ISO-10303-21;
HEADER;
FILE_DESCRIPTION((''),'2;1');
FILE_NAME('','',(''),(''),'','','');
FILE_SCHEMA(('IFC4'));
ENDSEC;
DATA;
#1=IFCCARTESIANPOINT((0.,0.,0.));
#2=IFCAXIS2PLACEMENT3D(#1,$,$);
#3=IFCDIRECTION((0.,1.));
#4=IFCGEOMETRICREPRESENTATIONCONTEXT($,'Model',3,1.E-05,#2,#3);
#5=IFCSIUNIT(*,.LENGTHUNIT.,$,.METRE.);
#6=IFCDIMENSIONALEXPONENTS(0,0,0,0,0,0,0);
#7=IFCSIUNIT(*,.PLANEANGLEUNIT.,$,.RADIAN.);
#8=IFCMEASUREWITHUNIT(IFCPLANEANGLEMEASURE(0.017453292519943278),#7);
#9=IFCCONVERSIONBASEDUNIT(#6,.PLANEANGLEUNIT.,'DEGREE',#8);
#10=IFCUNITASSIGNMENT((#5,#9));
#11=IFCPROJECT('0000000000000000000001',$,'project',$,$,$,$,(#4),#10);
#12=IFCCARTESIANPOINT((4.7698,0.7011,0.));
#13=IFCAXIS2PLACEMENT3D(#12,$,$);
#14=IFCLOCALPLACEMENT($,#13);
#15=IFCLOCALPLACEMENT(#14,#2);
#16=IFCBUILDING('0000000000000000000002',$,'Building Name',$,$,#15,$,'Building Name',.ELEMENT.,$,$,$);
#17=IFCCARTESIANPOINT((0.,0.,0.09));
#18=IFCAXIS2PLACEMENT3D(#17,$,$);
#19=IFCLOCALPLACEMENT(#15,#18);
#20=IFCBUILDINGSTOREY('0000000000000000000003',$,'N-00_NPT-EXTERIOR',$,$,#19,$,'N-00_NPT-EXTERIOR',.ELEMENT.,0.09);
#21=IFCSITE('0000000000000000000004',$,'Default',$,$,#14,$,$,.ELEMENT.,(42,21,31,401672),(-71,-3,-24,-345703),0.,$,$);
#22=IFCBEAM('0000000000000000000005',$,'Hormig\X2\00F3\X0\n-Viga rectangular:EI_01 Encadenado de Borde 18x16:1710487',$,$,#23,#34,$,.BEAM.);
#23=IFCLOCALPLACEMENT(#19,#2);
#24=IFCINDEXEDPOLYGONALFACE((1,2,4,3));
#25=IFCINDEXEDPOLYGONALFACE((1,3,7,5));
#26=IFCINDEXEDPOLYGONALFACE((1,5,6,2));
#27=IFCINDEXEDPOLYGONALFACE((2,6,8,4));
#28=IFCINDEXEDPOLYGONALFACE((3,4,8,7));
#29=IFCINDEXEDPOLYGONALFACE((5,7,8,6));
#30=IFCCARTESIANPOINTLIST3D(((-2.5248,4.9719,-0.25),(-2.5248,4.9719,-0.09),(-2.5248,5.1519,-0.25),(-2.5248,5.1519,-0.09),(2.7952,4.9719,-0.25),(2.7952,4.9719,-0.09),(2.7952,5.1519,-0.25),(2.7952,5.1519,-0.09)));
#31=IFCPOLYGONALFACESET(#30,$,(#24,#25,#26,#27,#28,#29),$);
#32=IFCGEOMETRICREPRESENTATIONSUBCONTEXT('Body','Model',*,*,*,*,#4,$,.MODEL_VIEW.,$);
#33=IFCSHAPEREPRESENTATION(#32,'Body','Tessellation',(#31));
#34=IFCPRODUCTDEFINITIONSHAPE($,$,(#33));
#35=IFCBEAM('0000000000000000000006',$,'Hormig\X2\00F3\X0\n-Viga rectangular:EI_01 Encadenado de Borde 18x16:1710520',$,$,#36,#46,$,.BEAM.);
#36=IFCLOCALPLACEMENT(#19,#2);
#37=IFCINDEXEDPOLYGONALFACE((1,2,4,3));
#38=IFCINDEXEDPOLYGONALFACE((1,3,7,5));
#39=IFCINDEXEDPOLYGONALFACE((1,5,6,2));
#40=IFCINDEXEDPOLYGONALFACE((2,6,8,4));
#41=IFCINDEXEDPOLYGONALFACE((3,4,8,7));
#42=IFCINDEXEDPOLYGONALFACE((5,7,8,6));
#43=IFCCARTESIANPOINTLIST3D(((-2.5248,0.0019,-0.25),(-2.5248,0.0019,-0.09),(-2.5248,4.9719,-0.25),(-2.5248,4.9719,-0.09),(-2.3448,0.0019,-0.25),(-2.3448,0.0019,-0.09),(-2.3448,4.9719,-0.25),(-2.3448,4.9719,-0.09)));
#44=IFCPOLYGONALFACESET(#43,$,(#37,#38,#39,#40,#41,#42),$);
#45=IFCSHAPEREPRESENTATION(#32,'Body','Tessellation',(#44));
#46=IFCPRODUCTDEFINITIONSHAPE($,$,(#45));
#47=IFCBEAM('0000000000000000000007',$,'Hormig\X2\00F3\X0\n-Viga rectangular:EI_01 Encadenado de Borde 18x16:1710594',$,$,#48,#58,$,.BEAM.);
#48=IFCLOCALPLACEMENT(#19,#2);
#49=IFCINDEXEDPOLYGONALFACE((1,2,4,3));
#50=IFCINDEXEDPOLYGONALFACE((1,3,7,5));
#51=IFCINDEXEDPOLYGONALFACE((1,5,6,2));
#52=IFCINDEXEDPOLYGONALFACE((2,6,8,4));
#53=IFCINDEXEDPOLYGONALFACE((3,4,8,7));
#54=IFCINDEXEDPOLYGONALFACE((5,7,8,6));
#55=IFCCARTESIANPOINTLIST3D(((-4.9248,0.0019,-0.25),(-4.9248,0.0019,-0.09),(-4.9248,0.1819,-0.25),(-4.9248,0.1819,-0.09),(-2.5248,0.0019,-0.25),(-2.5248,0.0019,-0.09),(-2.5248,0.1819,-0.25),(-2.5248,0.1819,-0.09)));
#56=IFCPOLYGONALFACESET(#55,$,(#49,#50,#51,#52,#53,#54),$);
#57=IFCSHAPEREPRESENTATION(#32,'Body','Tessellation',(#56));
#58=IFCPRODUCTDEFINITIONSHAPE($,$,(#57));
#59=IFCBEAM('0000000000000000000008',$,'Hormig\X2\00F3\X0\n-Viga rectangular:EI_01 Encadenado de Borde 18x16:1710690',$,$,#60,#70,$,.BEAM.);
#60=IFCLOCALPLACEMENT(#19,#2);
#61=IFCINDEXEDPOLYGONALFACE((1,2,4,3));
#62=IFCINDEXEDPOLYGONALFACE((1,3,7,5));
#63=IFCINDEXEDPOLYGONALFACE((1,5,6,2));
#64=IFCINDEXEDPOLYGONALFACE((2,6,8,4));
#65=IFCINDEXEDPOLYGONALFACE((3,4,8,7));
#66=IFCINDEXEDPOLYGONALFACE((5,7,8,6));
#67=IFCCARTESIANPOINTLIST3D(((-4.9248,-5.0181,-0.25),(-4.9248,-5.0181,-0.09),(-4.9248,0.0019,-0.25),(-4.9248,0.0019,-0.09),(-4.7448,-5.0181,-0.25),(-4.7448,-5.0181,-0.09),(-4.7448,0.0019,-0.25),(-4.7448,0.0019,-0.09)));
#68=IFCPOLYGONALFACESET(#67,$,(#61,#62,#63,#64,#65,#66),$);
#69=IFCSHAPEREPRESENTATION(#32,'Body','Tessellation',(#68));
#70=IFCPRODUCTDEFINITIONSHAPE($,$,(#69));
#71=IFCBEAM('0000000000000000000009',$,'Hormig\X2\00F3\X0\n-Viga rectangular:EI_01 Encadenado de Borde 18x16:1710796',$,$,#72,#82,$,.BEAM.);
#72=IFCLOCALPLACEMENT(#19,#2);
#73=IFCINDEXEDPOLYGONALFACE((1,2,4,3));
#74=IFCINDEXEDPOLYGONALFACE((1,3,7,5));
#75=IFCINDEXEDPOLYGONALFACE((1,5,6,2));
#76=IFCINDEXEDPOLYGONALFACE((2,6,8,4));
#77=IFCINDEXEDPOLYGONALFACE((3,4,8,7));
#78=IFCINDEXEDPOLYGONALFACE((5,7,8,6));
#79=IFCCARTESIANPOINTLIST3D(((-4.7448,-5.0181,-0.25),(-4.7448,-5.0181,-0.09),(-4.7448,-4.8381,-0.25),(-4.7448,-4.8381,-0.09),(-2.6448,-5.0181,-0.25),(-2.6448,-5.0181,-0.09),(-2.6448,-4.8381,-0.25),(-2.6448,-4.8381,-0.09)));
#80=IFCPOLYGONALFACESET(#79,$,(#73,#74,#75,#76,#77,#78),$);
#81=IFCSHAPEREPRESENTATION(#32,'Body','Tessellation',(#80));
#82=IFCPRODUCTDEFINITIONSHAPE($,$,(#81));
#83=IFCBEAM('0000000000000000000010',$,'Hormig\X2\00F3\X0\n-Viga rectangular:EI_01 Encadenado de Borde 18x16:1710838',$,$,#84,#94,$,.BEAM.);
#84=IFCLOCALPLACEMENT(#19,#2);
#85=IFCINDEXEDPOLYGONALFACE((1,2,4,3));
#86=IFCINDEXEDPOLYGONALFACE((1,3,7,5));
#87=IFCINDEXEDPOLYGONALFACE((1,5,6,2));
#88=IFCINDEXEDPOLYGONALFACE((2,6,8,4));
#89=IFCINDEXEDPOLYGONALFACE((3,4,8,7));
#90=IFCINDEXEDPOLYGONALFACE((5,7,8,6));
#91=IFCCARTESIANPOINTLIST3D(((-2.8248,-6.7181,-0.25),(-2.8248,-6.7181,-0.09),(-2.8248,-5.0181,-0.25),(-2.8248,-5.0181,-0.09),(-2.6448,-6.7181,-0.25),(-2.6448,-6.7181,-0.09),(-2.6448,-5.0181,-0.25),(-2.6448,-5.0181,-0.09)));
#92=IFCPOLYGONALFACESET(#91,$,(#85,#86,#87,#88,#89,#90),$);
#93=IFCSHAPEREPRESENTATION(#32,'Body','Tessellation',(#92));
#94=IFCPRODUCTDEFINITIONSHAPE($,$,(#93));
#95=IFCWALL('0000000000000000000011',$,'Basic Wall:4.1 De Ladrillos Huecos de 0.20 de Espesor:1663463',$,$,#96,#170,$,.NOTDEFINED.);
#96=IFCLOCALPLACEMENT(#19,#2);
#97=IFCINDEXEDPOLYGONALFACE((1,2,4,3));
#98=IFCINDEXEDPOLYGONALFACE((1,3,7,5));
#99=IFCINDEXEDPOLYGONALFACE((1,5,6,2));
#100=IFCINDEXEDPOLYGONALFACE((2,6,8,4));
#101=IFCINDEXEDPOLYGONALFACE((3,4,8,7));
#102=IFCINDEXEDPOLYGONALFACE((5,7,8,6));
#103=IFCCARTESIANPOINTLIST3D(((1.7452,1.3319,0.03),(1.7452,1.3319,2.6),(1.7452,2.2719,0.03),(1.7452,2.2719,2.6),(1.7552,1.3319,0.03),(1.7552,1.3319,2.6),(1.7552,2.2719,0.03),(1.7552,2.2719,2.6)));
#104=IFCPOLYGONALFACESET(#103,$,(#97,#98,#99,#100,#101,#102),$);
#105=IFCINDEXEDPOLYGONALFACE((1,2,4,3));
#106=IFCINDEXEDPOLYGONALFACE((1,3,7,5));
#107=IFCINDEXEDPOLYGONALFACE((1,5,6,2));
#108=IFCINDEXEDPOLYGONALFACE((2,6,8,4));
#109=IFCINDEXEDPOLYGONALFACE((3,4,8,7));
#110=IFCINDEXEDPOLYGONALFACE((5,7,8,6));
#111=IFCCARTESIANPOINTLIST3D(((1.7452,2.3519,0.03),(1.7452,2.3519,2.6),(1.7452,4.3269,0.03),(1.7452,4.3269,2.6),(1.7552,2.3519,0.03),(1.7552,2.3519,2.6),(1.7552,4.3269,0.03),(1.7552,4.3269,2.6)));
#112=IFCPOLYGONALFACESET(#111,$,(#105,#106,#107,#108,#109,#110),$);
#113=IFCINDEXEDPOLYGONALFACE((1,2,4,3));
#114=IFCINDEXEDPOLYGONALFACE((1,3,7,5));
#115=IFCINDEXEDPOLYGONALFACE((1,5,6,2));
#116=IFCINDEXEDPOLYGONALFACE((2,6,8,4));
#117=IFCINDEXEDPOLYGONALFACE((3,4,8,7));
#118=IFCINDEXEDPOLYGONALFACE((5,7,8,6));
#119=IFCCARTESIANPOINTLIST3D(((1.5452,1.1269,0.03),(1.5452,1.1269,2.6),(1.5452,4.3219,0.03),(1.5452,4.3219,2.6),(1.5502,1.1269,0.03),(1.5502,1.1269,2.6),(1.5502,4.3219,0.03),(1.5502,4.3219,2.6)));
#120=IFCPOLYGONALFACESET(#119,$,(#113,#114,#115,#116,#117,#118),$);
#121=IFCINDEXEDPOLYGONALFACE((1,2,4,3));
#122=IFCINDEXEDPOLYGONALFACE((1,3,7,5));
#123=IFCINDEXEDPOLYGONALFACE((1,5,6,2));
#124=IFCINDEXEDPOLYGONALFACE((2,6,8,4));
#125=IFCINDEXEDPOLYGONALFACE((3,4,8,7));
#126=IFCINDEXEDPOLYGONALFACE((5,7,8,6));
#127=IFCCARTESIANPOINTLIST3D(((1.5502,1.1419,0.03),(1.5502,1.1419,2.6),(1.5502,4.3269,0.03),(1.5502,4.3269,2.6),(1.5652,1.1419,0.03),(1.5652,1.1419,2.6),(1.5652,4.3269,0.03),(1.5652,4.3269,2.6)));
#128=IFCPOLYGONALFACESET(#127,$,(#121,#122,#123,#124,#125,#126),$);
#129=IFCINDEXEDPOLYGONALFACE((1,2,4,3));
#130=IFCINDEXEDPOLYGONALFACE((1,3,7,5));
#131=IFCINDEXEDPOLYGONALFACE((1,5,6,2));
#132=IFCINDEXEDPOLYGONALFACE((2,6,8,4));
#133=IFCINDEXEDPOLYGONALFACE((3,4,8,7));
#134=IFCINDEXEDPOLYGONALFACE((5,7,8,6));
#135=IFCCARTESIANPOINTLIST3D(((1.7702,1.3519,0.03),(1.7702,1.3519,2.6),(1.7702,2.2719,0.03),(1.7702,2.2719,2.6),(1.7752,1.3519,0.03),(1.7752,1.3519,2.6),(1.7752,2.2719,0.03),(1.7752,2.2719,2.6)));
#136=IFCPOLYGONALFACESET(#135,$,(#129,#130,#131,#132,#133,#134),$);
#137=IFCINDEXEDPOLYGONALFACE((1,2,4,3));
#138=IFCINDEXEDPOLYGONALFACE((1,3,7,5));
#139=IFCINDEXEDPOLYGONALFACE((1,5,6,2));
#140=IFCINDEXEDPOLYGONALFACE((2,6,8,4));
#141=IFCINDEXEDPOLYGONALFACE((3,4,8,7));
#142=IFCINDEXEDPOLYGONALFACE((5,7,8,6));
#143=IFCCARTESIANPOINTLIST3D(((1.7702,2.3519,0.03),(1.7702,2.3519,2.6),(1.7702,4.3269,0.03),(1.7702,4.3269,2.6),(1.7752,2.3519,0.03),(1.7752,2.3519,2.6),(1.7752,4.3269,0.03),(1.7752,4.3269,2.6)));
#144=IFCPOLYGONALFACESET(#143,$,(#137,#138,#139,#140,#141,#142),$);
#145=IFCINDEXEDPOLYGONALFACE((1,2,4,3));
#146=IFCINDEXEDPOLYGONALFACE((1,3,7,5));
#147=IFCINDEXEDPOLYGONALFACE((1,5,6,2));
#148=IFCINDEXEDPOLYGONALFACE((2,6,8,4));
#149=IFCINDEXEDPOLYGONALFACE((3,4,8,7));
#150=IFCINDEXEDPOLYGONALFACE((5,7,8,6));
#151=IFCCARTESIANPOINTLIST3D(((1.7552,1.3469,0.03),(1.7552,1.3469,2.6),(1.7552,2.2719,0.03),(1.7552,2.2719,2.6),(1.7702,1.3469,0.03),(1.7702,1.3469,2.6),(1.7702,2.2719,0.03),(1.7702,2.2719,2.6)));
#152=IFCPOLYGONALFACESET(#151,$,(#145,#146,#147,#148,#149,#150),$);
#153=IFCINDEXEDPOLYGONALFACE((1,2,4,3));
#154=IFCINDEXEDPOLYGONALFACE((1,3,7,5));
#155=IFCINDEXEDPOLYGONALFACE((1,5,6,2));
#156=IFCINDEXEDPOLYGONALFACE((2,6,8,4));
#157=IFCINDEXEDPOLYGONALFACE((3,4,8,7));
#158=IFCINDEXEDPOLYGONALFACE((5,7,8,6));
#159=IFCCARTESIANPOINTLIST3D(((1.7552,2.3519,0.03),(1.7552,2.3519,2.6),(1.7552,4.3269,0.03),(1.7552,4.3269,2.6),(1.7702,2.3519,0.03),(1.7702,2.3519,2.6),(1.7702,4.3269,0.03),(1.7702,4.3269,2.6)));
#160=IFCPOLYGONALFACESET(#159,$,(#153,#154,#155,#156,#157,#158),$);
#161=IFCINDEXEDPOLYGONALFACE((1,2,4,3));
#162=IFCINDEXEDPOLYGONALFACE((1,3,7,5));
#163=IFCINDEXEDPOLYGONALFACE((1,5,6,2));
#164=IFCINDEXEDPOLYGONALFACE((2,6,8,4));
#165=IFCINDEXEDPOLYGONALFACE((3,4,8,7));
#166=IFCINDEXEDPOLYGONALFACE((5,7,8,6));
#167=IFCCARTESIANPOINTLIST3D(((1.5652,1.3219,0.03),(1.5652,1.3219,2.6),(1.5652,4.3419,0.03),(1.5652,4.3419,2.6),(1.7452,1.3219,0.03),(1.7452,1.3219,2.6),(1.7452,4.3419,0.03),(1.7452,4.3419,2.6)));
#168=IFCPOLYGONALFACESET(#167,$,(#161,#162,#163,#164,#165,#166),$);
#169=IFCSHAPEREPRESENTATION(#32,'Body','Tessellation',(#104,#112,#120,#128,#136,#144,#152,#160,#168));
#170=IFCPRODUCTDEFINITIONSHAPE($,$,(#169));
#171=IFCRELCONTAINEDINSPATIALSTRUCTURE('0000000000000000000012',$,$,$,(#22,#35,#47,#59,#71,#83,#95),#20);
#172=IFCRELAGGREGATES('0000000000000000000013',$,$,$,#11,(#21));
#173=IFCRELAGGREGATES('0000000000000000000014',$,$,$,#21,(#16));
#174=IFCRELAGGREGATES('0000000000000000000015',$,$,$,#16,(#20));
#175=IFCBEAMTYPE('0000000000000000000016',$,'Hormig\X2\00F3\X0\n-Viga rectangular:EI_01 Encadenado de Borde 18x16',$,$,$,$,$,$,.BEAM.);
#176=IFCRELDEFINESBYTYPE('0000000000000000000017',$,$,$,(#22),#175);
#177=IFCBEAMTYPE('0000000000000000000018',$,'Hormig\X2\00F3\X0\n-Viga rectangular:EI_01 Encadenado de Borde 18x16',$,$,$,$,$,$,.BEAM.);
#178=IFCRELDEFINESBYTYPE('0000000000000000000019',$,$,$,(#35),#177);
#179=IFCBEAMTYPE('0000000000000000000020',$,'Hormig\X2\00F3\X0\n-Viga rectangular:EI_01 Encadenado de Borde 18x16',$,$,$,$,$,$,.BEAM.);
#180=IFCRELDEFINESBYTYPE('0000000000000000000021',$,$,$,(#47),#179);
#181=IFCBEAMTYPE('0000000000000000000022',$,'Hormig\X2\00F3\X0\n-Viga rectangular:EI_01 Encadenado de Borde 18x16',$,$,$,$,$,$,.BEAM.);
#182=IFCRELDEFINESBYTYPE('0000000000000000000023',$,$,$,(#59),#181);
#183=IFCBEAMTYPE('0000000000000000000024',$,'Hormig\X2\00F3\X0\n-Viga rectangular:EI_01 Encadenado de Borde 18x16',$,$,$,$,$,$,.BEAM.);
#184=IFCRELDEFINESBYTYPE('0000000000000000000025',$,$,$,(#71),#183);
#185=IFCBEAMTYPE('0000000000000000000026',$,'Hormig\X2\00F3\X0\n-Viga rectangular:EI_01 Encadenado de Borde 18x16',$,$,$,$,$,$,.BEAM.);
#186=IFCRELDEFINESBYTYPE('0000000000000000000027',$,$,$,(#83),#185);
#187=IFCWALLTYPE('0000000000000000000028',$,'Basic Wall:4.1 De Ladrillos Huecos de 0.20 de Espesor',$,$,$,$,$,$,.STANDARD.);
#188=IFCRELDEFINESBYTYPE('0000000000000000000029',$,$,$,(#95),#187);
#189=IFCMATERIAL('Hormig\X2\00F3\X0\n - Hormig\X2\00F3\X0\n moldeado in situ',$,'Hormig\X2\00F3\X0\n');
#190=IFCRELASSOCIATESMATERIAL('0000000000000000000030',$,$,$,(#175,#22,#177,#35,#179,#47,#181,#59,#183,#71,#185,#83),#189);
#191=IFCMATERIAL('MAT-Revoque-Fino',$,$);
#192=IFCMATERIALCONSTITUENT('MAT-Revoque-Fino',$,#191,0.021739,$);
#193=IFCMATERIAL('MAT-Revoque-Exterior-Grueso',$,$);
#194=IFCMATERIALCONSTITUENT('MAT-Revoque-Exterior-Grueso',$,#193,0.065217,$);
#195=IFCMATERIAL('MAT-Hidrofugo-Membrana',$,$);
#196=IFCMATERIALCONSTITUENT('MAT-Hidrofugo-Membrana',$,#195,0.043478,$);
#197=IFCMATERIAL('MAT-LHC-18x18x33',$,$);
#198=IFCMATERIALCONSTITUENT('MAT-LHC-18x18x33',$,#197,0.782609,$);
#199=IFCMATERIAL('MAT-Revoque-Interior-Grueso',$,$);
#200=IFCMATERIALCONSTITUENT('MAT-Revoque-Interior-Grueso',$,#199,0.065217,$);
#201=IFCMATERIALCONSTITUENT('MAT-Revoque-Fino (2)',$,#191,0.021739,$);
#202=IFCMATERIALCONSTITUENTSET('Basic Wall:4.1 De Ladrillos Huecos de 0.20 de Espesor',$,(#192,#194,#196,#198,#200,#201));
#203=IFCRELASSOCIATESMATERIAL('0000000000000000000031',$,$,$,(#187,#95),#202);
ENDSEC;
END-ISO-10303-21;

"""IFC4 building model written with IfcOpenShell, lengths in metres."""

from ifc_helpers import new_model, entity, si_unit, converted_unit, direction, frame, origin, place, context, subcontext, project, spatial, indexed_curve, outline, extrude, source, transform, mapped, material, constituent, constituent_set, type_object, type_shapes, element, save


model = new_model("IFC4")

# Units and contexts
model_context = context("Model", 3, precision=1e-05, world=origin(), true_north=direction((0.0, 1.0)))
body_context = subcontext(model_context, "Body", "Model", "MODEL_VIEW")
ifc_project = project(units=[si_unit("LENGTHUNIT", "METRE"), converted_unit("PLANEANGLEUNIT", "DEGREE", entity("IfcPlaneAngleMeasure", 0.017453292519943278), si_unit("PLANEANGLEUNIT", "RADIAN"), dimensions=[0, 0, 0, 0, 0, 0, 0])], contexts=[model_context])

# Site, building, storey
site_placement = place(None, frame((4.7698, 0.7011, 0.0)))
site = spatial("IfcSite", under=ifc_project, at=site_placement, Name="Default", CompositionType="ELEMENT", RefLatitude=(42, 21, 31, 401672), RefLongitude=(-71, -3, -24, -345703), RefElevation=0.0)
building_placement = place(site_placement, origin())
building = spatial("IfcBuilding", under=site, at=building_placement, Name="Building Name", LongName="Building Name", CompositionType="ELEMENT")
storey_placement = place(building_placement, frame((0.0, 0.0, 0.09)))
storey = spatial("IfcBuildingStorey", under=building, at=storey_placement, Name="N-00_NPT-EXTERIOR", LongName="N-00_NPT-EXTERIOR", CompositionType="ELEMENT", Elevation=0.09)

# Beams
ifc_material_1 = material(Name="Hormigón - Hormigón moldeado in situ", Category="Hormigón")
beam_type_1 = type_object("IfcBeamType", Name="Hormigón-Viga rectangular:EI_01 Encadenado de Borde 18x16", PredefinedType="BEAM", material=ifc_material_1)
shared_shape_1 = source(origin(), body_context, "Body", "SweptSolid", [
    extrude(outline(indexed_curve([(-0.08, -0.09), (0.08, -0.09), (0.08, 0.09), (-0.08, 0.09), (-0.08, -0.09)], self_intersect=False)), frame((2.7952, 5.0619, -0.08), z_axis=(-1.0, 0.0, 0.0), x_axis=(0.0, 0.0, -1.0)), (0.0, 0.0, 1.0), 5.32),
])
type_shapes(beam_type_1, [shared_shape_1])
beam_1_placement = place(storey_placement, frame((0.0, 0.0, -0.09)))
element("IfcBeam", 1, at=beam_1_placement, inside=storey, type_object=beam_type_1, material=ifc_material_1, Name="Hormigón-Viga rectangular:EI_01 Encadenado de Borde 18x16:1710487", PredefinedType="BEAM", context=body_context, shape_type="MappedRepresentation", body=[
    mapped(shared_shape_1, transform((0.0, 0.0, 0.0), scale=1.0)),
])
beam_type_2 = type_object("IfcBeamType", Name="Hormigón-Viga rectangular:EI_01 Encadenado de Borde 18x16", PredefinedType="BEAM", material=ifc_material_1)
shared_shape_2 = source(origin(), body_context, "Body", "SweptSolid", [
    extrude(outline(indexed_curve([(-0.09, -0.08), (0.09, -0.08), (0.09, 0.08), (-0.09, 0.08), (-0.09, -0.08)], self_intersect=False)), frame((-2.4348, 4.9719, -0.08), z_axis=(0.0, -1.0, 0.0), x_axis=(-1.0, 0.0, 0.0)), (0.0, 0.0, 1.0), 4.97),
])
type_shapes(beam_type_2, [shared_shape_2])
beam_2_placement = place(storey_placement, frame((0.0, 0.0, -0.09)))
element("IfcBeam", 2, at=beam_2_placement, inside=storey, type_object=beam_type_2, material=ifc_material_1, Name="Hormigón-Viga rectangular:EI_01 Encadenado de Borde 18x16:1710520", PredefinedType="BEAM", context=body_context, shape_type="MappedRepresentation", body=[
    mapped(shared_shape_2, transform((0.0, 0.0, 0.0), scale=1.0)),
])
beam_type_3 = type_object("IfcBeamType", Name="Hormigón-Viga rectangular:EI_01 Encadenado de Borde 18x16", PredefinedType="BEAM", material=ifc_material_1)
shared_shape_3 = source(origin(), body_context, "Body", "SweptSolid", [
    extrude(outline(indexed_curve([(-0.08, -0.09), (0.08, -0.09), (0.08, 0.09), (-0.08, 0.09), (-0.08, -0.09)], self_intersect=False)), frame((-2.5248, 0.0919, -0.08), z_axis=(-1.0, 0.0, 0.0), x_axis=(0.0, 0.0, -1.0)), (0.0, 0.0, 1.0), 2.4),
])
type_shapes(beam_type_3, [shared_shape_3])
beam_3_placement = place(storey_placement, frame((0.0, 0.0, -0.09)))
element("IfcBeam", 3, at=beam_3_placement, inside=storey, type_object=beam_type_3, material=ifc_material_1, Name="Hormigón-Viga rectangular:EI_01 Encadenado de Borde 18x16:1710594", PredefinedType="BEAM", context=body_context, shape_type="MappedRepresentation", body=[
    mapped(shared_shape_3, transform((0.0, 0.0, 0.0), scale=1.0)),
])
beam_type_4 = type_object("IfcBeamType", Name="Hormigón-Viga rectangular:EI_01 Encadenado de Borde 18x16", PredefinedType="BEAM", material=ifc_material_1)
shared_shape_4 = source(origin(), body_context, "Body", "SweptSolid", [
    extrude(outline(indexed_curve([(-0.09, -0.08), (0.09, -0.08), (0.09, 0.08), (-0.09, 0.08), (-0.09, -0.08)], self_intersect=False)), frame((-4.8348, 0.0019, -0.08), z_axis=(0.0, -1.0, 0.0), x_axis=(-1.0, 0.0, 0.0)), (0.0, 0.0, 1.0), 5.02),
])
type_shapes(beam_type_4, [shared_shape_4])
beam_4_placement = place(storey_placement, frame((0.0, 0.0, -0.09)))
element("IfcBeam", 4, at=beam_4_placement, inside=storey, type_object=beam_type_4, material=ifc_material_1, Name="Hormigón-Viga rectangular:EI_01 Encadenado de Borde 18x16:1710690", PredefinedType="BEAM", context=body_context, shape_type="MappedRepresentation", body=[
    mapped(shared_shape_4, transform((0.0, 0.0, 0.0), scale=1.0)),
])
beam_type_5 = type_object("IfcBeamType", Name="Hormigón-Viga rectangular:EI_01 Encadenado de Borde 18x16", PredefinedType="BEAM", material=ifc_material_1)
shared_shape_5 = source(origin(), body_context, "Body", "SweptSolid", [
    extrude(outline(indexed_curve([(-0.08, -0.09), (0.08, -0.09), (0.08, 0.09), (-0.08, 0.09), (-0.08, -0.09)], self_intersect=False)), frame((-4.7448, -4.9281, -0.08), z_axis=(1.0, 0.0, 0.0), x_axis=(0.0, 0.0, -1.0)), (0.0, 0.0, 1.0), 2.1),
])
type_shapes(beam_type_5, [shared_shape_5])
beam_5_placement = place(storey_placement, frame((0.0, 0.0, -0.09)))
element("IfcBeam", 5, at=beam_5_placement, inside=storey, type_object=beam_type_5, material=ifc_material_1, Name="Hormigón-Viga rectangular:EI_01 Encadenado de Borde 18x16:1710796", PredefinedType="BEAM", context=body_context, shape_type="MappedRepresentation", body=[
    mapped(shared_shape_5, transform((0.0, 0.0, 0.0), scale=1.0)),
])
beam_type_6 = type_object("IfcBeamType", Name="Hormigón-Viga rectangular:EI_01 Encadenado de Borde 18x16", PredefinedType="BEAM", material=ifc_material_1)
shared_shape_6 = source(origin(), body_context, "Body", "SweptSolid", [
    extrude(outline(indexed_curve([(-0.09, -0.08), (0.09, -0.08), (0.09, 0.08), (-0.09, 0.08), (-0.09, -0.08)], self_intersect=False)), frame((-2.7348, -5.0181, -0.08), z_axis=(0.0, -1.0, 0.0), x_axis=(-1.0, 0.0, 0.0)), (0.0, 0.0, 1.0), 1.7),
])
type_shapes(beam_type_6, [shared_shape_6])
beam_6_placement = place(storey_placement, frame((0.0, 0.0, -0.09)))
element("IfcBeam", 6, at=beam_6_placement, inside=storey, type_object=beam_type_6, material=ifc_material_1, Name="Hormigón-Viga rectangular:EI_01 Encadenado de Borde 18x16:1710838", PredefinedType="BEAM", context=body_context, shape_type="MappedRepresentation", body=[
    mapped(shared_shape_6, transform((0.0, 0.0, 0.0), scale=1.0)),
])

# Shared definitions
ifc_material_2 = material(Name="MAT-Revoque-Fino")
ifc_constituent_1 = constituent(ifc_material_2, Name="MAT-Revoque-Fino", fraction=0.021739)
ifc_material_3 = material(Name="MAT-Revoque-Exterior-Grueso")
ifc_constituent_2 = constituent(ifc_material_3, Name="MAT-Revoque-Exterior-Grueso", fraction=0.065217)
ifc_material_4 = material(Name="MAT-Hidrofugo-Membrana")
ifc_constituent_3 = constituent(ifc_material_4, Name="MAT-Hidrofugo-Membrana", fraction=0.043478)
ifc_material_5 = material(Name="MAT-LHC-18x18x33")
ifc_constituent_4 = constituent(ifc_material_5, Name="MAT-LHC-18x18x33", fraction=0.782609)
ifc_material_6 = material(Name="MAT-Revoque-Interior-Grueso")
ifc_constituent_5 = constituent(ifc_material_6, Name="MAT-Revoque-Interior-Grueso", fraction=0.065217)
ifc_constituent_6 = constituent(ifc_material_2, Name="MAT-Revoque-Fino (2)", fraction=0.021739)
ifc_constituent_set_1 = constituent_set(constituents=[ifc_constituent_1, ifc_constituent_2, ifc_constituent_3, ifc_constituent_4, ifc_constituent_5, ifc_constituent_6], Name="Basic Wall:4.1 De Ladrillos Huecos de 0.20 de Espesor")
wall_type_1 = type_object("IfcWallType", Name="Basic Wall:4.1 De Ladrillos Huecos de 0.20 de Espesor", PredefinedType="STANDARD", material=ifc_constituent_set_1)

# Wall
wall_1_placement = place(storey_placement, frame((1.6602, 4.3219, 0.03), z_axis=(0.0, 0.0, 1.0), x_axis=(0.0, -1.0, 0.0)))
element("IfcWall", 7, at=wall_1_placement, inside=storey, type_object=wall_type_1, material=ifc_constituent_set_1, Name="Basic Wall:4.1 De Ladrillos Huecos de 0.20 de Espesor:1663463", PredefinedType="NOTDEFINED", context=body_context, shape_type="SweptSolid", body=[
    extrude(outline(indexed_curve([(-0.47, -0.005), (0.47, -0.005), (0.47, 0.005), (-0.47, 0.005), (-0.47, -0.005)], self_intersect=False)), frame((2.52, 0.09, 0.0), z_axis=(0.0, 0.0, 1.0), x_axis=(-1.0, 0.0, 0.0)), (0.0, 0.0, 1.0), 2.57),
    extrude(outline(indexed_curve([(-0.9875, -0.005), (0.9875, -0.005), (0.9875, 0.005), (-0.9875, 0.005), (-0.9875, -0.005)], self_intersect=False)), frame((0.9825, 0.09, 0.0)), (0.0, 0.0, 1.0), 2.57),
    extrude(outline(indexed_curve([(-0.0025, -1.5975), (0.0025, -1.5975), (0.0025, 1.5975), (-0.0025, 1.5975), (-0.0025, -1.5975)], self_intersect=False)), frame((1.5975, -0.1125, 0.0), z_axis=(0.0, 0.0, 1.0), x_axis=(0.0, -1.0, 0.0)), (0.0, 0.0, 1.0), 2.57),
    extrude(outline(indexed_curve([(-0.0075, -1.5925), (0.0075, -1.5925), (0.0075, 1.5925), (-0.0075, 1.5925), (-0.0075, -1.5925)], self_intersect=False)), frame((1.5875, -0.1025, 0.0), z_axis=(0.0, 0.0, 1.0), x_axis=(0.0, 1.0, 0.0)), (0.0, 0.0, 1.0), 2.57),
    extrude(outline(indexed_curve([(-0.46, -0.0025), (0.46, -0.0025), (0.46, 0.0025), (-0.46, 0.0025), (-0.46, -0.0025)], self_intersect=False)), frame((2.51, 0.1125, 0.0), z_axis=(0.0, 0.0, 1.0), x_axis=(-1.0, 0.0, 0.0)), (0.0, 0.0, 1.0), 2.57),
    extrude(outline(indexed_curve([(-0.9875, -0.0025), (0.9875, -0.0025), (0.9875, 0.0025), (-0.9875, 0.0025), (-0.9875, -0.0025)], self_intersect=False)), frame((0.9825, 0.1125, 0.0)), (0.0, 0.0, 1.0), 2.57),
    extrude(outline(indexed_curve([(-0.4625, -0.0075), (0.4625, -0.0075), (0.4625, 0.0075), (-0.4625, 0.0075), (-0.4625, -0.0075)], self_intersect=False)), frame((2.5125, 0.1025, 0.0), z_axis=(0.0, 0.0, 1.0), x_axis=(-1.0, 0.0, 0.0)), (0.0, 0.0, 1.0), 2.57),
    extrude(outline(indexed_curve([(-0.9875, -0.0075), (0.9875, -0.0075), (0.9875, 0.0075), (-0.9875, 0.0075), (-0.9875, -0.0075)], self_intersect=False)), frame((0.9825, 0.1025, 0.0)), (0.0, 0.0, 1.0), 2.57),
    extrude(outline(indexed_curve([(-0.09, -1.51), (0.09, -1.51), (0.09, 1.51), (-0.09, 1.51), (-0.09, -1.51)], self_intersect=False)), frame((1.49, -0.005, 0.0), z_axis=(0.0, 0.0, 1.0), x_axis=(0.0, -1.0, 0.0)), (0.0, 0.0, 1.0), 2.57),
])

save(model, "model.ifc")
